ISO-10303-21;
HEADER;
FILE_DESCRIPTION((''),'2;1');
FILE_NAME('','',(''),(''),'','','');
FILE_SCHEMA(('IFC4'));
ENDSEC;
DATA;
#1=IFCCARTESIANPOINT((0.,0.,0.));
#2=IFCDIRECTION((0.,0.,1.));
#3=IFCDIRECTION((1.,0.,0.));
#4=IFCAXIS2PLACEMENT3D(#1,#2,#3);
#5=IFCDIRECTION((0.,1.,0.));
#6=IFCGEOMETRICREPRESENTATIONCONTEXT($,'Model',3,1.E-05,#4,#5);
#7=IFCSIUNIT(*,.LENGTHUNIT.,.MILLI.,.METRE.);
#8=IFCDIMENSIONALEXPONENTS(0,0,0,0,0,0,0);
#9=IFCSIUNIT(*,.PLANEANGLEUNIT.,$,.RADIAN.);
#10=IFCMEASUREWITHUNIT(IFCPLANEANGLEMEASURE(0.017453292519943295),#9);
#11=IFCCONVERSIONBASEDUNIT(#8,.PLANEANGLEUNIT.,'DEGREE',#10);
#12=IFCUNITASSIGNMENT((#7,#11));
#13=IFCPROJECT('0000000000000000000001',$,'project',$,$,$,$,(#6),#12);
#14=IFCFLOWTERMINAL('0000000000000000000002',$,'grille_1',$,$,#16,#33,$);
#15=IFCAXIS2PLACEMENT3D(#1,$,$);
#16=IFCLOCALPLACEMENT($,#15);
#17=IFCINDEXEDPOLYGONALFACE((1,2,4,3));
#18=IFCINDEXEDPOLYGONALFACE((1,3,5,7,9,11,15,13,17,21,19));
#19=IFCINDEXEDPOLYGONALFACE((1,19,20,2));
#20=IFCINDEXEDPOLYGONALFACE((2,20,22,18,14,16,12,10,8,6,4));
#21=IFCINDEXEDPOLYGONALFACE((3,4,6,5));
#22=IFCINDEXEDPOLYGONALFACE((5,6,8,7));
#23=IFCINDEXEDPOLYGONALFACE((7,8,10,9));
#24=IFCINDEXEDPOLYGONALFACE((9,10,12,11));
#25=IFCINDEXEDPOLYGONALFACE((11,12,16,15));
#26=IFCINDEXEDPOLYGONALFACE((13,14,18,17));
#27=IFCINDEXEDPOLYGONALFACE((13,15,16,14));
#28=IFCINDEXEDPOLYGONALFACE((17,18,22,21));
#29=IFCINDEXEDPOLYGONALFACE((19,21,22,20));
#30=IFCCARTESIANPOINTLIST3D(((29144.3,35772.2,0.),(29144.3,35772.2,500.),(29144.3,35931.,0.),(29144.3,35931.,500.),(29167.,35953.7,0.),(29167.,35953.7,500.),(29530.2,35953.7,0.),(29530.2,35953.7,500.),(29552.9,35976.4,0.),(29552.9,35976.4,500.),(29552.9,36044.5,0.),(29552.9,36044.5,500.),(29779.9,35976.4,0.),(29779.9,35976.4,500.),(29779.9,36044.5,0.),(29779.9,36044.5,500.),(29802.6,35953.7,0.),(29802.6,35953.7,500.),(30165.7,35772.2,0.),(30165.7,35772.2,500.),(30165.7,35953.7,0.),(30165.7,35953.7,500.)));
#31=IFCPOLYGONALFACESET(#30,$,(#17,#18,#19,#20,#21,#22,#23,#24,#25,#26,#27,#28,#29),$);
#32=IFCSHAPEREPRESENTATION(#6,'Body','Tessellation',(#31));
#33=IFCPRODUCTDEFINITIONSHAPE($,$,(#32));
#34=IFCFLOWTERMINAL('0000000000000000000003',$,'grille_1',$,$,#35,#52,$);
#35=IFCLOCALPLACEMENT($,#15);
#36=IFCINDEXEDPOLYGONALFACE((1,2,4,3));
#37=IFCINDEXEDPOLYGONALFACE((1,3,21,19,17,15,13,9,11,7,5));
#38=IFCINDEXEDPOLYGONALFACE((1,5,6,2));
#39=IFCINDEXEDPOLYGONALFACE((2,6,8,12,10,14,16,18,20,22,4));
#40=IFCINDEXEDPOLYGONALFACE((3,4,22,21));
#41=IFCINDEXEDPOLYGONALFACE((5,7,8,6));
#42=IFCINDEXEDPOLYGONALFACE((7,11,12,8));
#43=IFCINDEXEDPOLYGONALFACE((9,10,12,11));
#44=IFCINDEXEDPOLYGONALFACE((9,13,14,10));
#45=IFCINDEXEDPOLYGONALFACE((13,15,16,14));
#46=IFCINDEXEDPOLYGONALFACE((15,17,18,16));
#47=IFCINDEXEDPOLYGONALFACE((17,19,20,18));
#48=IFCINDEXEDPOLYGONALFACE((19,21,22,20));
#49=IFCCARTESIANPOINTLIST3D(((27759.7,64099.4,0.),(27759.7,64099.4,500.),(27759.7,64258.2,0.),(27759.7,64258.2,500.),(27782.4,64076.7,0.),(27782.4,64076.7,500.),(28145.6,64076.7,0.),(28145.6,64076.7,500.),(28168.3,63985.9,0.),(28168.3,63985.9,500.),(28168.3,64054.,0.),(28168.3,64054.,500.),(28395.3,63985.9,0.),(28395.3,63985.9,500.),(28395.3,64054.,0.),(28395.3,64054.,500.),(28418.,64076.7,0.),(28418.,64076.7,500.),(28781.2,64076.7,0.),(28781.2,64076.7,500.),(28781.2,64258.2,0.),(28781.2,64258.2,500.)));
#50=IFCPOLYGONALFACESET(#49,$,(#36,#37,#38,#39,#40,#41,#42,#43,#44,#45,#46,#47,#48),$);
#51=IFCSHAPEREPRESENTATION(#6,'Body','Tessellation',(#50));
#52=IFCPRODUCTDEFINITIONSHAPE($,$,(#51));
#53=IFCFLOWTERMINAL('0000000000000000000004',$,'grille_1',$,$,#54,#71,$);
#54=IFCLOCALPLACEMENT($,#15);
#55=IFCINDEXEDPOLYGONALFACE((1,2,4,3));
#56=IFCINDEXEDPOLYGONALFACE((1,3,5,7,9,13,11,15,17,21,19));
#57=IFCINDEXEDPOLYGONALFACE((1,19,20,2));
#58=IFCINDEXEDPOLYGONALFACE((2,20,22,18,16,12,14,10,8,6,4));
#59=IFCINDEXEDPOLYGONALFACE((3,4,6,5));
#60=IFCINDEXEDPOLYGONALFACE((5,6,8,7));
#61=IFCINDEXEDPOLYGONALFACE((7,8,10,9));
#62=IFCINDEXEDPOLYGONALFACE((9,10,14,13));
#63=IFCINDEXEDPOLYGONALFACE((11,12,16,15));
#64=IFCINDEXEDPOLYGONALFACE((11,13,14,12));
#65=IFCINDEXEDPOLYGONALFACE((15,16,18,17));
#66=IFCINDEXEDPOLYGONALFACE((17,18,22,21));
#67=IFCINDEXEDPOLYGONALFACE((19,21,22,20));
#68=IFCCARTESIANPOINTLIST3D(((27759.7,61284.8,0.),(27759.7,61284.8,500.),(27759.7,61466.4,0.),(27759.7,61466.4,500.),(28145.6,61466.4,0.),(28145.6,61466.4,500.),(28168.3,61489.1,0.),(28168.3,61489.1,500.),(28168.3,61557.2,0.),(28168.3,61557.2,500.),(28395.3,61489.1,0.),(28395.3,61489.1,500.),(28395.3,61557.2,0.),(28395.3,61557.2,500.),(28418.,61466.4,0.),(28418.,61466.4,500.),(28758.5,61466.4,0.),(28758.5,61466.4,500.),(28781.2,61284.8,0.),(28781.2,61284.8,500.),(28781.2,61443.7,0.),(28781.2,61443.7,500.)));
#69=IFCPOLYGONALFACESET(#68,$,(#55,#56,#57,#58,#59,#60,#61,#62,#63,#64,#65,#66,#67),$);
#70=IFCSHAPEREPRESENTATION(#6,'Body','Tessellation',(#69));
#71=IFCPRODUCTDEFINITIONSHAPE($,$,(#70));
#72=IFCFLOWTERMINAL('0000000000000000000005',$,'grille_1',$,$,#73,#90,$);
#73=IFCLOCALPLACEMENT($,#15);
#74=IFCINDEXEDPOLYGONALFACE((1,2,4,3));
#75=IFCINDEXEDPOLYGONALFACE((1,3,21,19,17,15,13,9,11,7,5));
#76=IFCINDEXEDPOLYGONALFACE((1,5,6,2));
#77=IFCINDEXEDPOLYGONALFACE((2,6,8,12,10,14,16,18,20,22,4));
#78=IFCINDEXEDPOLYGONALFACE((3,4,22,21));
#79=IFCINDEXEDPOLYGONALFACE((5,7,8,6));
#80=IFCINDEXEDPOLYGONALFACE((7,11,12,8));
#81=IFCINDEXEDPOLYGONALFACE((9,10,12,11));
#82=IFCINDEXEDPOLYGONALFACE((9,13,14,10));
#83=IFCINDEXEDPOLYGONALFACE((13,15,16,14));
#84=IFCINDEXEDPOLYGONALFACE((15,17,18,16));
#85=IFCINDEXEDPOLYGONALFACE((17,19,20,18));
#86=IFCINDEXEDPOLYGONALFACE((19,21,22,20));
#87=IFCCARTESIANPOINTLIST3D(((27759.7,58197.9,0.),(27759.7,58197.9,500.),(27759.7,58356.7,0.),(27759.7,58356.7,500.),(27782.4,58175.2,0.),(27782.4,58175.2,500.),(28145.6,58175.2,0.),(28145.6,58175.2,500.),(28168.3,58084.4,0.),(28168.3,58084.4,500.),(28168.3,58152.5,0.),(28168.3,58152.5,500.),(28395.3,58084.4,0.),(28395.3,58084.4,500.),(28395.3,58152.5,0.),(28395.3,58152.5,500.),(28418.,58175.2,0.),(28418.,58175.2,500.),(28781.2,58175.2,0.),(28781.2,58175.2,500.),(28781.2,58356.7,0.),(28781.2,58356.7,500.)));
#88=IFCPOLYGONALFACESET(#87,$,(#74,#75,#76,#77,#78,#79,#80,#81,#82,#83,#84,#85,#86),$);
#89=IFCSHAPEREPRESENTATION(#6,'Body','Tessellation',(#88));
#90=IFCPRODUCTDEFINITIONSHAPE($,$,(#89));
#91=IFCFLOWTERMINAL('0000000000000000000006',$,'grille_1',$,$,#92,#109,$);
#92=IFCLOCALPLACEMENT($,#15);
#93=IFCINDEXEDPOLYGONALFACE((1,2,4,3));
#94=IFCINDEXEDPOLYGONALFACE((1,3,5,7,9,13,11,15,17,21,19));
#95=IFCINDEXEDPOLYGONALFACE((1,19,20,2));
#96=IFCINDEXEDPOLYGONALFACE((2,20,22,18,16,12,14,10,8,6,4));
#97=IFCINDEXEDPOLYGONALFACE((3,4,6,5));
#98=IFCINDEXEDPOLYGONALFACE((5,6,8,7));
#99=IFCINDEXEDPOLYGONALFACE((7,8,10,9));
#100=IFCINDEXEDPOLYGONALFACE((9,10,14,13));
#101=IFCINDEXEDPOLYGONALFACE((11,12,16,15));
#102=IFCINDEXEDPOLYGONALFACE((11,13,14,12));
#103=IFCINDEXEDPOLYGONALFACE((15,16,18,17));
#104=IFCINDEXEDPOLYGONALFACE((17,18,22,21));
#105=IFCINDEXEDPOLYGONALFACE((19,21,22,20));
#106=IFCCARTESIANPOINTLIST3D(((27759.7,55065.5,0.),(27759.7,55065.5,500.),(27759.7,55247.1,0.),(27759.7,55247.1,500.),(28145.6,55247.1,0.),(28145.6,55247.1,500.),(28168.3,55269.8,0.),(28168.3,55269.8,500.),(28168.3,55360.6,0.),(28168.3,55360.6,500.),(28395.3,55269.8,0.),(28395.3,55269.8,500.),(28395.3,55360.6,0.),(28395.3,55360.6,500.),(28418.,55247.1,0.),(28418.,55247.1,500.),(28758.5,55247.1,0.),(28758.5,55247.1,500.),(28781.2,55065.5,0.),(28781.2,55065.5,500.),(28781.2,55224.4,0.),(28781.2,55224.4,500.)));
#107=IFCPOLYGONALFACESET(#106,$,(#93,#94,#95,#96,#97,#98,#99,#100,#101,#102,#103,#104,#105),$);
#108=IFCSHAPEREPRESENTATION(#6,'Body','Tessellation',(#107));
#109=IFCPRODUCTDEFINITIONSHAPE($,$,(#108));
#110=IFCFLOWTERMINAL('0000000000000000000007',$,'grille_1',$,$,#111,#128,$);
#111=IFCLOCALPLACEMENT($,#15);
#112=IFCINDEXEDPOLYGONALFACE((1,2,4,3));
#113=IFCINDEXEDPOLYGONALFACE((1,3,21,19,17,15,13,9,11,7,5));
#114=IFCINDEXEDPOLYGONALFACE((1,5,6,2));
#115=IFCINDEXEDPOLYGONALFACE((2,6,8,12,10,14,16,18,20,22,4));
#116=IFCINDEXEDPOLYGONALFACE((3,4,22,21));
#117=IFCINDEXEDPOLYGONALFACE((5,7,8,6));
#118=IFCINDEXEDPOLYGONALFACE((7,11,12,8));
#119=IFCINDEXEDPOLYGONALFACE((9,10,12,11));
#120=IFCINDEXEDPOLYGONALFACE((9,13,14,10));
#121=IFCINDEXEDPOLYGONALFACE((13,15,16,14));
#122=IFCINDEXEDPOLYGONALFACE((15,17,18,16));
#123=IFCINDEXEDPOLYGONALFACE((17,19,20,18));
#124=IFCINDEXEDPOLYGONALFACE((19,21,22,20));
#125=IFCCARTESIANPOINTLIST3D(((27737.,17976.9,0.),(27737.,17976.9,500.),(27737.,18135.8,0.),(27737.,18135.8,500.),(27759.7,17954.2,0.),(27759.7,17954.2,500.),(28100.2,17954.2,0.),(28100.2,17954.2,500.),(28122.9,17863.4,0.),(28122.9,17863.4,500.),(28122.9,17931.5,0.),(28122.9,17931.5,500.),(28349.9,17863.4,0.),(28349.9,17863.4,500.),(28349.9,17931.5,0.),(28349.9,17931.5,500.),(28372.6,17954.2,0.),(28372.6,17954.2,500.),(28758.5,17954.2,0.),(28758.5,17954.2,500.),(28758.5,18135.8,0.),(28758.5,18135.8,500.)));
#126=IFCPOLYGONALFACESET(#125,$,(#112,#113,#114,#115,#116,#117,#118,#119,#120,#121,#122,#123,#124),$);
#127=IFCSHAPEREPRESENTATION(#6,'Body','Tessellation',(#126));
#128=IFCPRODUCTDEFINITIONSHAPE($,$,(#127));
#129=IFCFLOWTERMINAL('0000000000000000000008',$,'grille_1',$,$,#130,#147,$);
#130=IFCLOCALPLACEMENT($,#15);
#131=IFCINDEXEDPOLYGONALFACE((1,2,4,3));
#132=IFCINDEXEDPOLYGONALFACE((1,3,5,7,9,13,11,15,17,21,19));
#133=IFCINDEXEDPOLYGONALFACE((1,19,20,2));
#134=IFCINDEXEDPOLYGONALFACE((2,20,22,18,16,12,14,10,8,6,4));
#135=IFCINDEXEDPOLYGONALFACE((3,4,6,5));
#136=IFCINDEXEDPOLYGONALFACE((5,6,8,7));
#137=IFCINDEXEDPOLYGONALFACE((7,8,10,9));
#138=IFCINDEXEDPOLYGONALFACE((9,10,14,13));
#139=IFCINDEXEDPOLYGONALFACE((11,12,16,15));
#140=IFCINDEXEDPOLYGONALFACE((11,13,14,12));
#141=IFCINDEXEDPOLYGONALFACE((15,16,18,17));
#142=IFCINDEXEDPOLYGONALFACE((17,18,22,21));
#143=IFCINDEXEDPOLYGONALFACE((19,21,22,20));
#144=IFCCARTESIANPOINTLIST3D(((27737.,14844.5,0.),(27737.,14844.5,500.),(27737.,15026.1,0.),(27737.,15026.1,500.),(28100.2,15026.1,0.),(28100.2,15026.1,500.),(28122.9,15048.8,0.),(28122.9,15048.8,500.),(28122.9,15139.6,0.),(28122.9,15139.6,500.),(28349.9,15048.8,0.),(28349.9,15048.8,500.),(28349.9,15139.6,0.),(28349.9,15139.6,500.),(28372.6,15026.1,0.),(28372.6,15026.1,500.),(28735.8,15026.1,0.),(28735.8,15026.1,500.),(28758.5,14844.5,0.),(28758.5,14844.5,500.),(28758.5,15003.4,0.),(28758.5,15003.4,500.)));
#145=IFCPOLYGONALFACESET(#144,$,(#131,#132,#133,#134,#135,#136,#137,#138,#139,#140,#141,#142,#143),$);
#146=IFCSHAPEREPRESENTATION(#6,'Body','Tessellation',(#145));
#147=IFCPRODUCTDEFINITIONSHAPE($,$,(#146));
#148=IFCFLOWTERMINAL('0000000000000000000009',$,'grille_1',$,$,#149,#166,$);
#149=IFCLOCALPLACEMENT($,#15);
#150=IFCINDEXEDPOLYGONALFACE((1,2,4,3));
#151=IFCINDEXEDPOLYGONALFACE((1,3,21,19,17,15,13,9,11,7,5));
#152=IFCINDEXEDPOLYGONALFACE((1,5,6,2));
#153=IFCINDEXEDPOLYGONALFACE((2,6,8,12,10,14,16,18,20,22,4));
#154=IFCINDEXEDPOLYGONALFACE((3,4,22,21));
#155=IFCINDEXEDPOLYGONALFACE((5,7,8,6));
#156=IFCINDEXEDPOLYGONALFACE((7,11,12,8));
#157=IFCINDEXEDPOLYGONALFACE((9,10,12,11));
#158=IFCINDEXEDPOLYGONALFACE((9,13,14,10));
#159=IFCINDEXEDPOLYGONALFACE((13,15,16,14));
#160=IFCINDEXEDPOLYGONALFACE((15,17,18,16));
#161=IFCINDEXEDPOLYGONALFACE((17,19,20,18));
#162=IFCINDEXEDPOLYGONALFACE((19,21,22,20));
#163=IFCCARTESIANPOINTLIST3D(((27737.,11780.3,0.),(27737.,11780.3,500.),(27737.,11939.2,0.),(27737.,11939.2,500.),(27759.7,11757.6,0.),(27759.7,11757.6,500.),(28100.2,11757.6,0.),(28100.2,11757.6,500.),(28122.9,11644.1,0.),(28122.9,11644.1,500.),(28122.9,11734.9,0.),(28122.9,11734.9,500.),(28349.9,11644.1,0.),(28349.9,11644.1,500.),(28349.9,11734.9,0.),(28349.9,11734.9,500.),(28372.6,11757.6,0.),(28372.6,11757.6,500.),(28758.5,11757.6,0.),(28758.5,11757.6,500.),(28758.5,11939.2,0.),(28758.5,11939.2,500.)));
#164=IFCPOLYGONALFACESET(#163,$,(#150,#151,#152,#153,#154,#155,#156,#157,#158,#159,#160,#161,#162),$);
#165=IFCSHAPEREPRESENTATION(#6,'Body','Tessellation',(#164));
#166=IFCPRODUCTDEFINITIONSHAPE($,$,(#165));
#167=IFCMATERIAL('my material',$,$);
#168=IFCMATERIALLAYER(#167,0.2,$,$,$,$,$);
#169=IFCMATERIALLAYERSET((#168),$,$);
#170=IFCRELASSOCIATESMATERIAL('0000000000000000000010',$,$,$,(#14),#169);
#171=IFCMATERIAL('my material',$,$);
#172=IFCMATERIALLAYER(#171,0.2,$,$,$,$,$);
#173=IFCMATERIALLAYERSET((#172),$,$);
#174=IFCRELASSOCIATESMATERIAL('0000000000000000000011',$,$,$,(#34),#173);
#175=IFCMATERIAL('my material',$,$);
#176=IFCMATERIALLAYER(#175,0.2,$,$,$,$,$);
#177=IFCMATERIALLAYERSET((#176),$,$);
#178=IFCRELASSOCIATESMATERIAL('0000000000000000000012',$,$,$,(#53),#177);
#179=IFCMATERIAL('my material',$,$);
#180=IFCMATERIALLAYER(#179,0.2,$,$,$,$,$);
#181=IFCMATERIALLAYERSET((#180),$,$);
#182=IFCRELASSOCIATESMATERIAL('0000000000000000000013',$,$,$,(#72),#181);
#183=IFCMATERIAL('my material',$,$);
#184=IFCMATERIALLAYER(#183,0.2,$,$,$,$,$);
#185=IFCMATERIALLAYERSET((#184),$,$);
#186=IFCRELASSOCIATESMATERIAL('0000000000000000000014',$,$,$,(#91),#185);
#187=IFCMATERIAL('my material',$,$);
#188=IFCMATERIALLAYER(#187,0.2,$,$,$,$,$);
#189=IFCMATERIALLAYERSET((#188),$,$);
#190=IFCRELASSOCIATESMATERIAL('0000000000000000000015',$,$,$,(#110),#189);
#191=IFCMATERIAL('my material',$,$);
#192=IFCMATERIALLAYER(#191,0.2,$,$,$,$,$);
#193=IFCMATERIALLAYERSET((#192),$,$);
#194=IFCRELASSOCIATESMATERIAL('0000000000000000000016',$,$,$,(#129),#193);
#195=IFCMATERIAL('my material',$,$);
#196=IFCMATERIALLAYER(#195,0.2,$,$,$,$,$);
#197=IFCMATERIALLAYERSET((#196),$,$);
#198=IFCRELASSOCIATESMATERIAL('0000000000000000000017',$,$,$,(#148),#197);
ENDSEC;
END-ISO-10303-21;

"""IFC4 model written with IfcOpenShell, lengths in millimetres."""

from ifc_helpers import new_model, entity, si_unit, converted_unit, direction, origin_with_axes, place, context, project, polyline, outline, extrude, material, layer, layer_set, layer_usage, element, save


model = new_model("IFC4")

# Units and contexts
model_context = context("Model", 3, precision=1e-05, world=origin_with_axes(), true_north=direction((0.0, 1.0, 0.0)))
ifc_project = project(units=[si_unit("LENGTHUNIT", "METRE", prefix="MILLI"), converted_unit("PLANEANGLEUNIT", "DEGREE", entity("IfcPlaneAngleMeasure", 0.017453292519943295), si_unit("PLANEANGLEUNIT", "RADIAN"), dimensions=[0, 0, 0, 0, 0, 0, 0])], contexts=[model_context])

# Flow terminals
ifc_material_1 = material(Name="my material")
ifc_layer_1 = layer(ifc_material_1, 0.2)
ifc_layer_set_1 = layer_set([ifc_layer_1])
ifc_layer_usage_1 = layer_usage(ifc_layer_set_1, "AXIS2", "POSITIVE", -0.1)
flow_terminal_1_placement = place(None, origin_with_axes())
element("IfcFlowTerminal", 1, at=flow_terminal_1_placement, material=ifc_layer_usage_1, Name="grille_1", context=model_context, shape_type="SweptSolid", body=[
    extrude(outline(polyline([(29144.3, 35772.2), (30165.7, 35772.2), (30165.7, 35953.7), (29802.6, 35953.7), (29779.9, 35976.4), (29779.9, 36044.5), (29552.9, 36044.5), (29552.9, 35976.4), (29530.2, 35953.7), (29167.0, 35953.7), (29144.3, 35931.0), (29144.3, 35772.2)])), origin_with_axes(), (0.0, 0.0, 1.0), 500.0),
])
ifc_material_2 = material(Name="my material")
ifc_layer_2 = layer(ifc_material_2, 0.2)
ifc_layer_set_2 = layer_set([ifc_layer_2])
ifc_layer_usage_2 = layer_usage(ifc_layer_set_2, "AXIS2", "POSITIVE", -0.1)
flow_terminal_2_placement = place(None, origin_with_axes())
element("IfcFlowTerminal", 2, at=flow_terminal_2_placement, material=ifc_layer_usage_2, Name="grille_1", context=model_context, shape_type="SweptSolid", body=[
    extrude(outline(polyline([(27759.7, 64099.4), (27782.4, 64076.7), (28145.6, 64076.7), (28168.3, 64054.0), (28168.3, 63985.9), (28395.3, 63985.9), (28395.3, 64054.0), (28418.0, 64076.7), (28781.2, 64076.7), (28781.2, 64258.2), (27759.7, 64258.2), (27759.7, 64099.4)])), origin_with_axes(), (0.0, 0.0, 1.0), 500.0),
])
ifc_material_3 = material(Name="my material")
ifc_layer_3 = layer(ifc_material_3, 0.2)
ifc_layer_set_3 = layer_set([ifc_layer_3])
ifc_layer_usage_3 = layer_usage(ifc_layer_set_3, "AXIS2", "POSITIVE", -0.1)
flow_terminal_3_placement = place(None, origin_with_axes())
element("IfcFlowTerminal", 3, at=flow_terminal_3_placement, material=ifc_layer_usage_3, Name="grille_1", context=model_context, shape_type="SweptSolid", body=[
    extrude(outline(polyline([(27759.7, 61284.8), (28781.2, 61284.8), (28781.2, 61443.7), (28758.5, 61466.4), (28418.0, 61466.4), (28395.3, 61489.1), (28395.3, 61557.2), (28168.3, 61557.2), (28168.3, 61489.1), (28145.6, 61466.4), (27759.7, 61466.4), (27759.7, 61284.8)])), origin_with_axes(), (0.0, 0.0, 1.0), 500.0),
])
ifc_material_4 = material(Name="my material")
ifc_layer_4 = layer(ifc_material_4, 0.2)
ifc_layer_set_4 = layer_set([ifc_layer_4])
ifc_layer_usage_4 = layer_usage(ifc_layer_set_4, "AXIS2", "POSITIVE", -0.1)
flow_terminal_4_placement = place(None, origin_with_axes())
element("IfcFlowTerminal", 4, at=flow_terminal_4_placement, material=ifc_layer_usage_4, Name="grille_1", context=model_context, shape_type="SweptSolid", body=[
    extrude(outline(polyline([(27759.7, 58197.9), (27782.4, 58175.2), (28145.6, 58175.2), (28168.3, 58152.5), (28168.3, 58084.4), (28395.3, 58084.4), (28395.3, 58152.5), (28418.0, 58175.2), (28781.2, 58175.2), (28781.2, 58356.7), (27759.7, 58356.7), (27759.7, 58197.9)])), origin_with_axes(), (0.0, 0.0, 1.0), 500.0),
])
ifc_material_5 = material(Name="my material")
ifc_layer_5 = layer(ifc_material_5, 0.2)
ifc_layer_set_5 = layer_set([ifc_layer_5])
ifc_layer_usage_5 = layer_usage(ifc_layer_set_5, "AXIS2", "POSITIVE", -0.1)
flow_terminal_5_placement = place(None, origin_with_axes())
element("IfcFlowTerminal", 5, at=flow_terminal_5_placement, material=ifc_layer_usage_5, Name="grille_1", context=model_context, shape_type="SweptSolid", body=[
    extrude(outline(polyline([(27759.7, 55065.5), (28781.2, 55065.5), (28781.2, 55224.4), (28758.5, 55247.1), (28418.0, 55247.1), (28395.3, 55269.8), (28395.3, 55360.6), (28168.3, 55360.6), (28168.3, 55269.8), (28145.6, 55247.1), (27759.7, 55247.1), (27759.7, 55065.5)])), origin_with_axes(), (0.0, 0.0, 1.0), 500.0),
])
ifc_material_6 = material(Name="my material")
ifc_layer_6 = layer(ifc_material_6, 0.2)
ifc_layer_set_6 = layer_set([ifc_layer_6])
ifc_layer_usage_6 = layer_usage(ifc_layer_set_6, "AXIS2", "POSITIVE", -0.1)
flow_terminal_6_placement = place(None, origin_with_axes())
element("IfcFlowTerminal", 6, at=flow_terminal_6_placement, material=ifc_layer_usage_6, Name="grille_1", context=model_context, shape_type="SweptSolid", body=[
    extrude(outline(polyline([(27737.0, 17976.9), (27759.7, 17954.2), (28100.2, 17954.2), (28122.9, 17931.5), (28122.9, 17863.4), (28349.9, 17863.4), (28349.9, 17931.5), (28372.6, 17954.2), (28758.5, 17954.2), (28758.5, 18135.8), (27737.0, 18135.8), (27737.0, 17976.9)])), origin_with_axes(), (0.0, 0.0, 1.0), 500.0),
])
ifc_material_7 = material(Name="my material")
ifc_layer_7 = layer(ifc_material_7, 0.2)
ifc_layer_set_7 = layer_set([ifc_layer_7])
ifc_layer_usage_7 = layer_usage(ifc_layer_set_7, "AXIS2", "POSITIVE", -0.1)
flow_terminal_7_placement = place(None, origin_with_axes())
element("IfcFlowTerminal", 7, at=flow_terminal_7_placement, material=ifc_layer_usage_7, Name="grille_1", context=model_context, shape_type="SweptSolid", body=[
    extrude(outline(polyline([(27737.0, 14844.5), (28758.5, 14844.5), (28758.5, 15003.4), (28735.8, 15026.1), (28372.6, 15026.1), (28349.9, 15048.8), (28349.9, 15139.6), (28122.9, 15139.6), (28122.9, 15048.8), (28100.2, 15026.1), (27737.0, 15026.1), (27737.0, 14844.5)])), origin_with_axes(), (0.0, 0.0, 1.0), 500.0),
])
ifc_material_8 = material(Name="my material")
ifc_layer_8 = layer(ifc_material_8, 0.2)
ifc_layer_set_8 = layer_set([ifc_layer_8])
ifc_layer_usage_8 = layer_usage(ifc_layer_set_8, "AXIS2", "POSITIVE", -0.1)
flow_terminal_8_placement = place(None, origin_with_axes())
element("IfcFlowTerminal", 8, at=flow_terminal_8_placement, material=ifc_layer_usage_8, Name="grille_1", context=model_context, shape_type="SweptSolid", body=[
    extrude(outline(polyline([(27737.0, 11780.3), (27759.7, 11757.6), (28100.2, 11757.6), (28122.9, 11734.9), (28122.9, 11644.1), (28349.9, 11644.1), (28349.9, 11734.9), (28372.6, 11757.6), (28758.5, 11757.6), (28758.5, 11939.2), (27737.0, 11939.2), (27737.0, 11780.3)])), origin_with_axes(), (0.0, 0.0, 1.0), 500.0),
])

save(model, "model.ifc")
